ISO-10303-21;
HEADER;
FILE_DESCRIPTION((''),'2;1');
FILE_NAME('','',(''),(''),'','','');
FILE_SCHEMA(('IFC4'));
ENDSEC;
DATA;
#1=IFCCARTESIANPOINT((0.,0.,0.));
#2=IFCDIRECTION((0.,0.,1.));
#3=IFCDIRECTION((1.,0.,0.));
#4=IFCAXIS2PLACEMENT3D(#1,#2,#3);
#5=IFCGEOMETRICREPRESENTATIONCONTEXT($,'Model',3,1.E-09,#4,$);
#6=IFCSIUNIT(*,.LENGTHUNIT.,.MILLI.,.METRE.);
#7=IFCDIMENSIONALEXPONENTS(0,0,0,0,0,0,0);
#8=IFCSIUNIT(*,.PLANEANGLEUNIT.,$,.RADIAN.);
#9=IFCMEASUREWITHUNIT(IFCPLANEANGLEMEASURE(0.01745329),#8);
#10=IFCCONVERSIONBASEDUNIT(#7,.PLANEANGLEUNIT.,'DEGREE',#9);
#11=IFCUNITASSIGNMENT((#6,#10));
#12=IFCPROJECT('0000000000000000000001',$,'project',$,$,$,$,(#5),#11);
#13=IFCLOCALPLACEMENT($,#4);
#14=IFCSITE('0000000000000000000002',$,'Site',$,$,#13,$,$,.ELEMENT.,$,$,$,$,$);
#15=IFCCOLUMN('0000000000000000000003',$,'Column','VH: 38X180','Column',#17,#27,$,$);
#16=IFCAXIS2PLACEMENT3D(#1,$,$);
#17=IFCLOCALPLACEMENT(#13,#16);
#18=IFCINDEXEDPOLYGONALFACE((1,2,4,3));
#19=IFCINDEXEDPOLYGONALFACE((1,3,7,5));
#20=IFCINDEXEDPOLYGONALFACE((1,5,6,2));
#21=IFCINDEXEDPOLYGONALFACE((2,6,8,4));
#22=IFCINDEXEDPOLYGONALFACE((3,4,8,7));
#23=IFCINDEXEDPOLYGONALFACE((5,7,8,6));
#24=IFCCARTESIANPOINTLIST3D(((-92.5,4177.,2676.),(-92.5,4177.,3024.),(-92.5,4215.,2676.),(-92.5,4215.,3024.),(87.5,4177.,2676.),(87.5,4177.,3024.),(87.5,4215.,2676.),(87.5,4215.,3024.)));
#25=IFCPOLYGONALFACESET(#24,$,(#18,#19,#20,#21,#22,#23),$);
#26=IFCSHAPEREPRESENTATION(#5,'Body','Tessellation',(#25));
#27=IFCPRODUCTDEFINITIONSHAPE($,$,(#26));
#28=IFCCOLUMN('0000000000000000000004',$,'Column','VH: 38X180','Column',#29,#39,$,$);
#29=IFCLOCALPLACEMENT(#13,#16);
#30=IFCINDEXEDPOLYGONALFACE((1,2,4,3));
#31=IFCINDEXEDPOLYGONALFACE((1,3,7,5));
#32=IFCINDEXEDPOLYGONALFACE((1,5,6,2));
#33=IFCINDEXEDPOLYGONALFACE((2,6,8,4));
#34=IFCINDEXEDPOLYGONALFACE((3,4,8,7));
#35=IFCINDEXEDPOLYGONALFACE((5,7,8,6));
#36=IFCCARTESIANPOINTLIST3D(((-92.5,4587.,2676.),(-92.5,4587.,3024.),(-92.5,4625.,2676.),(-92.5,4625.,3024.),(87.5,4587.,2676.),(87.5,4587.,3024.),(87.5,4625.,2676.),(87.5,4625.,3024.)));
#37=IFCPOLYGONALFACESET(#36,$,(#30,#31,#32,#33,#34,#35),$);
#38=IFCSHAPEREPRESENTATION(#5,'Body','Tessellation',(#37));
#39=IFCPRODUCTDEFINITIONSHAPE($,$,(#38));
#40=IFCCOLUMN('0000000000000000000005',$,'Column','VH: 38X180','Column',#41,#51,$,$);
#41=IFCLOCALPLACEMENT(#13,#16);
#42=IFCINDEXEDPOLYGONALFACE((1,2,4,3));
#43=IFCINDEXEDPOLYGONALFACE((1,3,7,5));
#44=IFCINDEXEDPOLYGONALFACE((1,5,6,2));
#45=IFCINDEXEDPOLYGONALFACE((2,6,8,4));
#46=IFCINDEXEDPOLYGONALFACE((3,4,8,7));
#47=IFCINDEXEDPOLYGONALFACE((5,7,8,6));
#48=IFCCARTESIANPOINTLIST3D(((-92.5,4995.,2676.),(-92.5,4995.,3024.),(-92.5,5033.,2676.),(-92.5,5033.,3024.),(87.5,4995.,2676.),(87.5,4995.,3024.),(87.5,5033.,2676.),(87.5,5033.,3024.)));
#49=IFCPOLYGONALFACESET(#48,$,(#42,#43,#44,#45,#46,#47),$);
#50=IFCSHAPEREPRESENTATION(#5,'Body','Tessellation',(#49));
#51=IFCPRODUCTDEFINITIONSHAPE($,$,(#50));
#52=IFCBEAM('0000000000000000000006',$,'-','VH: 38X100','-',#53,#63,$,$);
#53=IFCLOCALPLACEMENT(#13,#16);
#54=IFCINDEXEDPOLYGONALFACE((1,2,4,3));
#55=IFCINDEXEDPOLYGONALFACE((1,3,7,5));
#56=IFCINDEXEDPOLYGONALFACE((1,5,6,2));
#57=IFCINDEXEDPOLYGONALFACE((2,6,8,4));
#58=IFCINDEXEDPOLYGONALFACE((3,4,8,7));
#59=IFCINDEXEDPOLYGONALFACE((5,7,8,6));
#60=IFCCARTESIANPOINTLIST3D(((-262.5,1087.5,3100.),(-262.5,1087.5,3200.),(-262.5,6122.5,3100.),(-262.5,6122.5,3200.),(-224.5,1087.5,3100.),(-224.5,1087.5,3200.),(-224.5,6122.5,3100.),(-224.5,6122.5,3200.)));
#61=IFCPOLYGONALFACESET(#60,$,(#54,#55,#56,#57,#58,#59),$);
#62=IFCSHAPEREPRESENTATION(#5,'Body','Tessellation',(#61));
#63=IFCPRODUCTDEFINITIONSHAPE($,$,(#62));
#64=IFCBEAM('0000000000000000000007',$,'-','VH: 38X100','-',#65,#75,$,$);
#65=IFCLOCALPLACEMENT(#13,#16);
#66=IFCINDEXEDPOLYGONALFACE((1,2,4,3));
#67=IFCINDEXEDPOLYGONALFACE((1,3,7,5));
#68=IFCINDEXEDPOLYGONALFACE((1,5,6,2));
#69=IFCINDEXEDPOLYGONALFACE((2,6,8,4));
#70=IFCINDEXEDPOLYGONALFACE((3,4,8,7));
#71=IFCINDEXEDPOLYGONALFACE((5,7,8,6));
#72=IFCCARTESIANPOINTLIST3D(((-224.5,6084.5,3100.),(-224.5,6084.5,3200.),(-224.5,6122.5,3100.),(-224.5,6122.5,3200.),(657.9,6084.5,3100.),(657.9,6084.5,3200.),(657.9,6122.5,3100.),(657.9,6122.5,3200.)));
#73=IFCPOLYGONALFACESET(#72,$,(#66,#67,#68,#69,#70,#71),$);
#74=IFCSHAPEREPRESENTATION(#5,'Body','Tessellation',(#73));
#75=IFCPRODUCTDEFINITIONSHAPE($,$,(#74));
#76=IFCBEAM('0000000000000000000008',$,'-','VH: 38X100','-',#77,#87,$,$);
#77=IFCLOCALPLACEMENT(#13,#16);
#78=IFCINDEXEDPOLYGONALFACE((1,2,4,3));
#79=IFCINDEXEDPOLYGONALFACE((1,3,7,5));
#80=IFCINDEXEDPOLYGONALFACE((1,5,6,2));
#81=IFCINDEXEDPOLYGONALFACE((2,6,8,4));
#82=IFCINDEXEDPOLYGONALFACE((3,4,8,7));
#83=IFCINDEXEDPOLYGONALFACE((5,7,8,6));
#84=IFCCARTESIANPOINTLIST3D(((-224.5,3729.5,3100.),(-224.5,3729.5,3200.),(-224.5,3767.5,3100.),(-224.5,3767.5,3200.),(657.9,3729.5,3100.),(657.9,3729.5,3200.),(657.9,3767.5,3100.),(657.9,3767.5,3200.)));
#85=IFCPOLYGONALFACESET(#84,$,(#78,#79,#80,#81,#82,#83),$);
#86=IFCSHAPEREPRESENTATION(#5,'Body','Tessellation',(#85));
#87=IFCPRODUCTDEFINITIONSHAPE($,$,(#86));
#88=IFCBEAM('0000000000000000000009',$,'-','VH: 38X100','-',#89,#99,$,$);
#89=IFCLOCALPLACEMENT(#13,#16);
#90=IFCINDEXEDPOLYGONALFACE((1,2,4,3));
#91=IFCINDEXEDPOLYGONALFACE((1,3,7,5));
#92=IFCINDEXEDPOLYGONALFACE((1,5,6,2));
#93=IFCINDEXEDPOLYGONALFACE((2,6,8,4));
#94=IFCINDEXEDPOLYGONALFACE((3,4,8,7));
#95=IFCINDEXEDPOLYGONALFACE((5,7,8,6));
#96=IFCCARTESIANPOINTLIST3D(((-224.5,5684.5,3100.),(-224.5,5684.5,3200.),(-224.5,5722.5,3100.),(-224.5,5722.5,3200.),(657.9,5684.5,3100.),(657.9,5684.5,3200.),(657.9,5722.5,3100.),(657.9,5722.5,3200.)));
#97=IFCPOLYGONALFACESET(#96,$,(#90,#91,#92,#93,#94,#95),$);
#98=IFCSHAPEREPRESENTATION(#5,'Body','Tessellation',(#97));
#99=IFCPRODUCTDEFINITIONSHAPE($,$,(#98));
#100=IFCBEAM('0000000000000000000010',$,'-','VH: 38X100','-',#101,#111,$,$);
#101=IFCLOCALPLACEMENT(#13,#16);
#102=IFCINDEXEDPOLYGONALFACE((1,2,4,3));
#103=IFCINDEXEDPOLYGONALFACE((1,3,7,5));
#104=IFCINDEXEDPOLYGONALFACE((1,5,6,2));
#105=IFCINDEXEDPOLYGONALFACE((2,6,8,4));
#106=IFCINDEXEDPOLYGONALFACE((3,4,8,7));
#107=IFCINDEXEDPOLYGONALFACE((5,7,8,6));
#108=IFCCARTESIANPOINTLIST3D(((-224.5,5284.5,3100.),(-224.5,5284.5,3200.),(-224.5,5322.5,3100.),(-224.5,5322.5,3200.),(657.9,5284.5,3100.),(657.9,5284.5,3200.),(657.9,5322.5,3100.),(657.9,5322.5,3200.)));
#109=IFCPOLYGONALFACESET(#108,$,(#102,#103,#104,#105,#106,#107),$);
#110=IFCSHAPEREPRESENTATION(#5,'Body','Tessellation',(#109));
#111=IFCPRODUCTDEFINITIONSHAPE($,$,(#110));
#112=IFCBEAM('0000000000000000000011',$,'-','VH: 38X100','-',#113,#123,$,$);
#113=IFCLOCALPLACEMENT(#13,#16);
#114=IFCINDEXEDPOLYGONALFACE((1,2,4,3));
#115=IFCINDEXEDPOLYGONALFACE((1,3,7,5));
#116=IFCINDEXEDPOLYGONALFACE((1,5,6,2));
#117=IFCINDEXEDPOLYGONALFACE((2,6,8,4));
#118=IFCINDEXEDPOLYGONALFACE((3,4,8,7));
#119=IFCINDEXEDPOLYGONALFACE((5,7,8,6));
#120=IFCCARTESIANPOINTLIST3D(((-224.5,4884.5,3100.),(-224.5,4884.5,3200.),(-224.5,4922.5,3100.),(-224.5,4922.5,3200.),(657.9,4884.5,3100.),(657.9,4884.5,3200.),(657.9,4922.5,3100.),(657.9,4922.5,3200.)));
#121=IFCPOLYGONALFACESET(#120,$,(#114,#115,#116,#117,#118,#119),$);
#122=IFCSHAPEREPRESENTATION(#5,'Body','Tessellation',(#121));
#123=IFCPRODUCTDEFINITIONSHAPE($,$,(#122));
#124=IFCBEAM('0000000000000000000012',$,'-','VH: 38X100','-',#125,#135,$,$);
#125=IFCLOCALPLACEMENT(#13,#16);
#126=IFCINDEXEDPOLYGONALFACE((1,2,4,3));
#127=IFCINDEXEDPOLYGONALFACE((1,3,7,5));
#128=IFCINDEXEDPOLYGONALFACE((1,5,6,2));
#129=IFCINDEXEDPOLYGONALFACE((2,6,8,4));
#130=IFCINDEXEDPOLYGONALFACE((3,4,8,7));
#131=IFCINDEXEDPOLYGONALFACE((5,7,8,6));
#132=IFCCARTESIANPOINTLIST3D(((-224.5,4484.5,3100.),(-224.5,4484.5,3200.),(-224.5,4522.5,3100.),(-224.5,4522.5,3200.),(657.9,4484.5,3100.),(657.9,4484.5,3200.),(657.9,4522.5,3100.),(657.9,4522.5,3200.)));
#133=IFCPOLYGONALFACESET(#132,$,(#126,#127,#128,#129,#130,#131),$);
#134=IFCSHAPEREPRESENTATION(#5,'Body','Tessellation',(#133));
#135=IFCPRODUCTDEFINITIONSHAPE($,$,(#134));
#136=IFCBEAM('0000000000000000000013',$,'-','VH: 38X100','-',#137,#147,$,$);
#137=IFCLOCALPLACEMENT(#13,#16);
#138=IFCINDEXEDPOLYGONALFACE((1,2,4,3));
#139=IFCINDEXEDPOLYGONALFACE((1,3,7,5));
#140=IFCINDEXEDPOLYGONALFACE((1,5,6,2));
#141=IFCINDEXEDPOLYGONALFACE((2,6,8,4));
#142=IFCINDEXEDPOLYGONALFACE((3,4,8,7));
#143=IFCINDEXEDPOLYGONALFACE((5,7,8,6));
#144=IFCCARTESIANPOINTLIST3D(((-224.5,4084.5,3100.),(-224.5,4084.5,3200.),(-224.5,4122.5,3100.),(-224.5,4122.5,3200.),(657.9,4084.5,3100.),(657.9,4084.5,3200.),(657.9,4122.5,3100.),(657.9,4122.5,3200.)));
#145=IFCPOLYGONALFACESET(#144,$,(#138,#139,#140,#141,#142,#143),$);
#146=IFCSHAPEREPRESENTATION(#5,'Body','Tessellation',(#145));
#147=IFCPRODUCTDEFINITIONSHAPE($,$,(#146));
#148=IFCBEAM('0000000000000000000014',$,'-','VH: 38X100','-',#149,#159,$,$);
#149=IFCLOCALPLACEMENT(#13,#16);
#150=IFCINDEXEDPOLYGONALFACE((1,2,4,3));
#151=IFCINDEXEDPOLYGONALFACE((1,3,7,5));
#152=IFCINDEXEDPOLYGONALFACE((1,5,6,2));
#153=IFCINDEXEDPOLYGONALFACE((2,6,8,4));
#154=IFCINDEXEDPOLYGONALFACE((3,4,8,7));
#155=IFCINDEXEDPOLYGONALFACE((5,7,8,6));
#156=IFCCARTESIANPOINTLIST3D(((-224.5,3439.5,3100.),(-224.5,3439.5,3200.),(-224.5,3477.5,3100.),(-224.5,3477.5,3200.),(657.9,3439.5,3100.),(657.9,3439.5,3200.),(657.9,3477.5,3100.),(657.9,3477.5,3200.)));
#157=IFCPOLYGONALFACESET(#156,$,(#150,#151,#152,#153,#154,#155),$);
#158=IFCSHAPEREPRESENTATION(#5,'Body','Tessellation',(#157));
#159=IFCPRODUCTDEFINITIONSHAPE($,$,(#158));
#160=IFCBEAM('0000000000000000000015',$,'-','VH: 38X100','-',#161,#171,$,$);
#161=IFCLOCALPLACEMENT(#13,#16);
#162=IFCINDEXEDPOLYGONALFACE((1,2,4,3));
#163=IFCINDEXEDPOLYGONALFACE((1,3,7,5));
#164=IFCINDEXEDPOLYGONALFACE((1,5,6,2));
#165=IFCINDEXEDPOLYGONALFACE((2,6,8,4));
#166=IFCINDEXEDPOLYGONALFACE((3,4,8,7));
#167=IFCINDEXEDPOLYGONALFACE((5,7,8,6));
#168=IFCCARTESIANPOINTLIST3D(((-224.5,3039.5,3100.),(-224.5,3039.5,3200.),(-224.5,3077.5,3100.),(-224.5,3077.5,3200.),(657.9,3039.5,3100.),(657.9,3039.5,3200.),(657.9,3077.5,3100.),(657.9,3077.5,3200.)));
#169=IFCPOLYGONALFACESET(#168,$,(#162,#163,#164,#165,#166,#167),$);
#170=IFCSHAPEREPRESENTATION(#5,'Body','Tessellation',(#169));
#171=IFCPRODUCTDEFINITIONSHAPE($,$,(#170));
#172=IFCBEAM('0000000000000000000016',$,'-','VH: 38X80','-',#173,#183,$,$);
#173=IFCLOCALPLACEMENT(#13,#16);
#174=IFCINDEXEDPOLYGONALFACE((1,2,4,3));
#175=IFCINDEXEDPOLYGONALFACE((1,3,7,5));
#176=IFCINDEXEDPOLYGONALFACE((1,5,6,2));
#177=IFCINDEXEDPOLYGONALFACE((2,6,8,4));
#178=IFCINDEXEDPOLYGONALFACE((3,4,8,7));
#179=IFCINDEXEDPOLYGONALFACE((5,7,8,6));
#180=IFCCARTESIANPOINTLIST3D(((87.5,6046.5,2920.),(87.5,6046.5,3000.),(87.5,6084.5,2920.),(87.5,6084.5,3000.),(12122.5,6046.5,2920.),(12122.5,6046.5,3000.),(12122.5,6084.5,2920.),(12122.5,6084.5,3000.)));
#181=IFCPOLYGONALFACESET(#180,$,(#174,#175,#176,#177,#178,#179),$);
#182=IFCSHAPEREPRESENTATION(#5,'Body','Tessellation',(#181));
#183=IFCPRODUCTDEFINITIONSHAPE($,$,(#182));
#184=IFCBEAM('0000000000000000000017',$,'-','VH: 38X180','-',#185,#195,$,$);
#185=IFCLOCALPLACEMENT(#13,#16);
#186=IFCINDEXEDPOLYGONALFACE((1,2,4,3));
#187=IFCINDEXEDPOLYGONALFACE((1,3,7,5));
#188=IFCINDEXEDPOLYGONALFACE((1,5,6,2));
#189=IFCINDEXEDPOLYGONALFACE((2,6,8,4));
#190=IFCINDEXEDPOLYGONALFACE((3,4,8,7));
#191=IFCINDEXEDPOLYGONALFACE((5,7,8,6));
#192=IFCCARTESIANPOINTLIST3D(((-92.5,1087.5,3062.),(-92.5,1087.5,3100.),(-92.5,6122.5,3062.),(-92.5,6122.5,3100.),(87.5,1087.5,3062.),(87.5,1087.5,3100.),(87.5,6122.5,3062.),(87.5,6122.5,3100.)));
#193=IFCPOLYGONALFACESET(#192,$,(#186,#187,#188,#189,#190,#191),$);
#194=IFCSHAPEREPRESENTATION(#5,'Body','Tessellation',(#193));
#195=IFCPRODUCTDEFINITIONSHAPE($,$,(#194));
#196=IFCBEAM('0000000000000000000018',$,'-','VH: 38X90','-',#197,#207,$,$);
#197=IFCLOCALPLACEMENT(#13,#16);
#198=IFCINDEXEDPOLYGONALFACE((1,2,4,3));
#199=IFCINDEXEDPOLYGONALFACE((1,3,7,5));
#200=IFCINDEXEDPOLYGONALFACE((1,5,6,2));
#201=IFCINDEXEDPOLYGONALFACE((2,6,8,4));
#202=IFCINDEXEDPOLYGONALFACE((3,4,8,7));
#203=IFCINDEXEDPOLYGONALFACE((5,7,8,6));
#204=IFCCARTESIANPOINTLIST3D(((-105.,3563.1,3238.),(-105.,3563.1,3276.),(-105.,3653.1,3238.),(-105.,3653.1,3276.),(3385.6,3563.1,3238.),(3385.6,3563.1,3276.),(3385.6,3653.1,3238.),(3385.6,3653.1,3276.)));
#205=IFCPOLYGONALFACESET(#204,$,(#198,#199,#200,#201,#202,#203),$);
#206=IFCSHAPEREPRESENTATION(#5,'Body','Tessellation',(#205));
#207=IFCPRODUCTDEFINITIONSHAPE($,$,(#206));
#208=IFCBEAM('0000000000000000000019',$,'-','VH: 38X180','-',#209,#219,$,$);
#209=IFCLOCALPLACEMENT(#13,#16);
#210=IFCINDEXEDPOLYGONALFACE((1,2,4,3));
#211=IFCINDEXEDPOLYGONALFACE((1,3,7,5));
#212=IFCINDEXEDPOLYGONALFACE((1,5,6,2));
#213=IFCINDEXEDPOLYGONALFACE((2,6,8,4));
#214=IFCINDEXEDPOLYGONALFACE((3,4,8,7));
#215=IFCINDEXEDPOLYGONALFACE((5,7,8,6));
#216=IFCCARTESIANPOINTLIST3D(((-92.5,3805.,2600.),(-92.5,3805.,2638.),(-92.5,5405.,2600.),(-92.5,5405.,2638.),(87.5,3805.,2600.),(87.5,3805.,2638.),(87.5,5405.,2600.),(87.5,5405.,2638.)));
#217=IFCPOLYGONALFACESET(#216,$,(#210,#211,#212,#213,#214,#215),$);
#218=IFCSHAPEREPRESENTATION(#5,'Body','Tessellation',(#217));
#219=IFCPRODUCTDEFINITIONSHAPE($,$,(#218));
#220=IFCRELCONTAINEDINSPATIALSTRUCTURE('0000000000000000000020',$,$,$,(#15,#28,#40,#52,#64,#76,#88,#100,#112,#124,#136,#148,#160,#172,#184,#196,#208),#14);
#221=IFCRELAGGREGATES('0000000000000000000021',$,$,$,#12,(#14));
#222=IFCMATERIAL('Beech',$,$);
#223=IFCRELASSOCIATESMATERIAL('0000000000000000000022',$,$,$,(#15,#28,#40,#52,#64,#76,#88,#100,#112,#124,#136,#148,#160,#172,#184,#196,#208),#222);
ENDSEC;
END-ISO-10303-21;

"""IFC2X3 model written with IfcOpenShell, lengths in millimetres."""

from ifc_helpers import new_model, entity, si_unit, converted_unit, frame, origin, origin_with_axes, origin_2d, place, context, project, spatial, rectangle, extrude, material, element, save


model = new_model("IFC2X3")

# Units and contexts
model_context = context("Model", 3, precision=1e-09, world=origin_with_axes())
ifc_project = project(units=[si_unit("LENGTHUNIT", "METRE", prefix="MILLI"), converted_unit("PLANEANGLEUNIT", "DEGREE", entity("IfcPlaneAngleMeasure", 0.01745329), si_unit("PLANEANGLEUNIT", "RADIAN"), dimensions=[0, 0, 0, 0, 0, 0, 0])], contexts=[model_context])

# Site
site_placement = place(None, origin_with_axes())
site = spatial("IfcSite", under=ifc_project, at=site_placement, Name="Site", CompositionType="ELEMENT")

# Columns
ifc_material = material(Name="Beech")
for number, where, z_axis, x_axis, name in (
    (1, (-2.5, 4196.0, 2676.0), (0.0, 0.0, -1.0), (0.0, -1.0, 0.0), "Column"),
    (2, (-2.5, 4606.0, 2676.0), (0.0, 0.0, -1.0), (0.0, -1.0, 0.0), "Column"),
    (3, (-2.5, 5014.0, 2676.0), (0.0, 0.0, -1.0), (0.0, -1.0, 0.0), "Column"),
):
    element("IfcColumn", number, at=place(None, frame(where, z_axis=z_axis, x_axis=x_axis)), inside=site, material=ifc_material, Name=name, Description="VH: 38X180", ObjectType="Column", context=model_context, shape_type="SweptSolid", body=[
        extrude(rectangle(XDim=38.0, YDim=180.0, at=origin_2d()), origin(), (0.0, 0.0, -1.0), 348.0),
    ])

# Beams
beam_1_placement = place(None, frame((-243.5, 6122.5, 3150.0), z_axis=(0.000003, 1.0, 0.0), x_axis=(-1.0, 0.000003, 0.0)))
element("IfcBeam", 4, at=beam_1_placement, inside=site, material=ifc_material, Name="-", Description="VH: 38X100", ObjectType="-", context=model_context, shape_type="SweptSolid", body=[
    extrude(rectangle(XDim=38.0, YDim=100.0, at=origin_2d()), origin(), (0.0, 0.0, -1.0), 5035.0),
])
beam_2_placement = place(None, frame((657.9, 6103.5, 3150.0), z_axis=(1.0, -0.000018, 0.0), x_axis=(0.000018, 1.0, 0.0)))
element("IfcBeam", 5, at=beam_2_placement, inside=site, material=ifc_material, Name="-", Description="VH: 38X100", ObjectType="-", context=model_context, shape_type="SweptSolid", body=[
    extrude(rectangle(XDim=38.0, YDim=100.0, at=origin_2d()), origin(), (0.0, 0.0, -1.0), 882.4),
])
beam_3_placement = place(None, frame((657.9, 3748.5, 3150.0), z_axis=(1.0, -0.000018, 0.0), x_axis=(0.000018, 1.0, 0.0)))
element("IfcBeam", 6, at=beam_3_placement, inside=site, material=ifc_material, Name="-", Description="VH: 38X100", ObjectType="-", context=model_context, shape_type="SweptSolid", body=[
    extrude(rectangle(XDim=38.0, YDim=100.0, at=origin_2d()), origin(), (0.0, 0.0, -1.0), 882.4),
])
beam_4_placement = place(None, frame((657.9, 5703.5, 3150.0), z_axis=(1.0, -0.000018, 0.0), x_axis=(0.000018, 1.0, 0.0)))
element("IfcBeam", 7, at=beam_4_placement, inside=site, material=ifc_material, Name="-", Description="VH: 38X100", ObjectType="-", context=model_context, shape_type="SweptSolid", body=[
    extrude(rectangle(XDim=38.0, YDim=100.0, at=origin_2d()), origin(), (0.0, 0.0, -1.0), 882.4),
])
beam_5_placement = place(None, frame((657.9, 5303.5, 3150.0), z_axis=(1.0, -0.000018, 0.0), x_axis=(0.000018, 1.0, 0.0)))
element("IfcBeam", 8, at=beam_5_placement, inside=site, material=ifc_material, Name="-", Description="VH: 38X100", ObjectType="-", context=model_context, shape_type="SweptSolid", body=[
    extrude(rectangle(XDim=38.0, YDim=100.0, at=origin_2d()), origin(), (0.0, 0.0, -1.0), 882.4),
])
beam_6_placement = place(None, frame((657.9, 4903.5, 3150.0), z_axis=(1.0, -0.000018, 0.0), x_axis=(0.000018, 1.0, 0.0)))
element("IfcBeam", 9, at=beam_6_placement, inside=site, material=ifc_material, Name="-", Description="VH: 38X100", ObjectType="-", context=model_context, shape_type="SweptSolid", body=[
    extrude(rectangle(XDim=38.0, YDim=100.0, at=origin_2d()), origin(), (0.0, 0.0, -1.0), 882.4),
])
beam_7_placement = place(None, frame((657.9, 4503.5, 3150.0), z_axis=(1.0, -0.000018, 0.0), x_axis=(0.000018, 1.0, 0.0)))
element("IfcBeam", 10, at=beam_7_placement, inside=site, material=ifc_material, Name="-", Description="VH: 38X100", ObjectType="-", context=model_context, shape_type="SweptSolid", body=[
    extrude(rectangle(XDim=38.0, YDim=100.0, at=origin_2d()), origin(), (0.0, 0.0, -1.0), 882.4),
])
beam_8_placement = place(None, frame((657.9, 4103.5, 3150.0), z_axis=(1.0, -0.000018, 0.0), x_axis=(0.000018, 1.0, 0.0)))
element("IfcBeam", 11, at=beam_8_placement, inside=site, material=ifc_material, Name="-", Description="VH: 38X100", ObjectType="-", context=model_context, shape_type="SweptSolid", body=[
    extrude(rectangle(XDim=38.0, YDim=100.0, at=origin_2d()), origin(), (0.0, 0.0, -1.0), 882.4),
])
beam_9_placement = place(None, frame((657.9, 3458.5, 3150.0), z_axis=(1.0, -0.000018, 0.0), x_axis=(0.000018, 1.0, 0.0)))
element("IfcBeam", 12, at=beam_9_placement, inside=site, material=ifc_material, Name="-", Description="VH: 38X100", ObjectType="-", context=model_context, shape_type="SweptSolid", body=[
    extrude(rectangle(XDim=38.0, YDim=100.0, at=origin_2d()), origin(), (0.0, 0.0, -1.0), 882.4),
])
beam_10_placement = place(None, frame((657.9, 3058.5, 3150.0), z_axis=(1.0, -0.000018, 0.0), x_axis=(0.000018, 1.0, 0.0)))
element("IfcBeam", 13, at=beam_10_placement, inside=site, material=ifc_material, Name="-", Description="VH: 38X100", ObjectType="-", context=model_context, shape_type="SweptSolid", body=[
    extrude(rectangle(XDim=38.0, YDim=100.0, at=origin_2d()), origin(), (0.0, 0.0, -1.0), 882.4),
])
beam_11_placement = place(None, frame((87.5, 6065.5, 2960.0), z_axis=(-1.0, 0.0, 0.0), x_axis=(0.0, -1.0, 0.0)))
element("IfcBeam", 14, at=beam_11_placement, inside=site, material=ifc_material, Name="-", Description="VH: 38X80", ObjectType="-", context=model_context, shape_type="SweptSolid", body=[
    extrude(rectangle(XDim=38.0, YDim=80.0, at=origin_2d()), origin(), (0.0, 0.0, -1.0), 12035.0),
])
beam_12_placement = place(None, frame((-2.5, 6122.5, 3081.0), z_axis=(0.0, -1.0, 0.0), x_axis=(0.0, 0.0, 1.0)))
element("IfcBeam", 15, at=beam_12_placement, inside=site, material=ifc_material, Name="-", Description="VH: 38X180", ObjectType="-", context=model_context, shape_type="SweptSolid", body=[
    extrude(rectangle(XDim=38.0, YDim=180.0, at=origin_2d()), origin(), (0.0, 0.0, 1.0), 5035.0),
])
beam_13_placement = place(None, frame((-105.0, 3608.1, 3257.0), z_axis=(-1.0, 0.0, 0.0), x_axis=(0.0, 0.0, -1.0)))
element("IfcBeam", 16, at=beam_13_placement, inside=site, material=ifc_material, Name="-", Description="VH: 38X90", ObjectType="-", context=model_context, shape_type="SweptSolid", body=[
    extrude(rectangle(XDim=38.0, YDim=90.0, at=origin_2d()), origin(), (0.0, 0.0, -1.0), 3490.7),
])
beam_14_placement = place(None, frame((-2.5, 5405.0, 2619.0), z_axis=(0.0, -1.0, 0.0), x_axis=(0.0, 0.0, 1.0)))
element("IfcBeam", 17, at=beam_14_placement, inside=site, material=ifc_material, Name="-", Description="VH: 38X180", ObjectType="-", context=model_context, shape_type="SweptSolid", body=[
    extrude(rectangle(XDim=38.0, YDim=180.0, at=origin_2d()), origin(), (0.0, 0.0, 1.0), 1600.0),
])

save(model, "model.ifc")
